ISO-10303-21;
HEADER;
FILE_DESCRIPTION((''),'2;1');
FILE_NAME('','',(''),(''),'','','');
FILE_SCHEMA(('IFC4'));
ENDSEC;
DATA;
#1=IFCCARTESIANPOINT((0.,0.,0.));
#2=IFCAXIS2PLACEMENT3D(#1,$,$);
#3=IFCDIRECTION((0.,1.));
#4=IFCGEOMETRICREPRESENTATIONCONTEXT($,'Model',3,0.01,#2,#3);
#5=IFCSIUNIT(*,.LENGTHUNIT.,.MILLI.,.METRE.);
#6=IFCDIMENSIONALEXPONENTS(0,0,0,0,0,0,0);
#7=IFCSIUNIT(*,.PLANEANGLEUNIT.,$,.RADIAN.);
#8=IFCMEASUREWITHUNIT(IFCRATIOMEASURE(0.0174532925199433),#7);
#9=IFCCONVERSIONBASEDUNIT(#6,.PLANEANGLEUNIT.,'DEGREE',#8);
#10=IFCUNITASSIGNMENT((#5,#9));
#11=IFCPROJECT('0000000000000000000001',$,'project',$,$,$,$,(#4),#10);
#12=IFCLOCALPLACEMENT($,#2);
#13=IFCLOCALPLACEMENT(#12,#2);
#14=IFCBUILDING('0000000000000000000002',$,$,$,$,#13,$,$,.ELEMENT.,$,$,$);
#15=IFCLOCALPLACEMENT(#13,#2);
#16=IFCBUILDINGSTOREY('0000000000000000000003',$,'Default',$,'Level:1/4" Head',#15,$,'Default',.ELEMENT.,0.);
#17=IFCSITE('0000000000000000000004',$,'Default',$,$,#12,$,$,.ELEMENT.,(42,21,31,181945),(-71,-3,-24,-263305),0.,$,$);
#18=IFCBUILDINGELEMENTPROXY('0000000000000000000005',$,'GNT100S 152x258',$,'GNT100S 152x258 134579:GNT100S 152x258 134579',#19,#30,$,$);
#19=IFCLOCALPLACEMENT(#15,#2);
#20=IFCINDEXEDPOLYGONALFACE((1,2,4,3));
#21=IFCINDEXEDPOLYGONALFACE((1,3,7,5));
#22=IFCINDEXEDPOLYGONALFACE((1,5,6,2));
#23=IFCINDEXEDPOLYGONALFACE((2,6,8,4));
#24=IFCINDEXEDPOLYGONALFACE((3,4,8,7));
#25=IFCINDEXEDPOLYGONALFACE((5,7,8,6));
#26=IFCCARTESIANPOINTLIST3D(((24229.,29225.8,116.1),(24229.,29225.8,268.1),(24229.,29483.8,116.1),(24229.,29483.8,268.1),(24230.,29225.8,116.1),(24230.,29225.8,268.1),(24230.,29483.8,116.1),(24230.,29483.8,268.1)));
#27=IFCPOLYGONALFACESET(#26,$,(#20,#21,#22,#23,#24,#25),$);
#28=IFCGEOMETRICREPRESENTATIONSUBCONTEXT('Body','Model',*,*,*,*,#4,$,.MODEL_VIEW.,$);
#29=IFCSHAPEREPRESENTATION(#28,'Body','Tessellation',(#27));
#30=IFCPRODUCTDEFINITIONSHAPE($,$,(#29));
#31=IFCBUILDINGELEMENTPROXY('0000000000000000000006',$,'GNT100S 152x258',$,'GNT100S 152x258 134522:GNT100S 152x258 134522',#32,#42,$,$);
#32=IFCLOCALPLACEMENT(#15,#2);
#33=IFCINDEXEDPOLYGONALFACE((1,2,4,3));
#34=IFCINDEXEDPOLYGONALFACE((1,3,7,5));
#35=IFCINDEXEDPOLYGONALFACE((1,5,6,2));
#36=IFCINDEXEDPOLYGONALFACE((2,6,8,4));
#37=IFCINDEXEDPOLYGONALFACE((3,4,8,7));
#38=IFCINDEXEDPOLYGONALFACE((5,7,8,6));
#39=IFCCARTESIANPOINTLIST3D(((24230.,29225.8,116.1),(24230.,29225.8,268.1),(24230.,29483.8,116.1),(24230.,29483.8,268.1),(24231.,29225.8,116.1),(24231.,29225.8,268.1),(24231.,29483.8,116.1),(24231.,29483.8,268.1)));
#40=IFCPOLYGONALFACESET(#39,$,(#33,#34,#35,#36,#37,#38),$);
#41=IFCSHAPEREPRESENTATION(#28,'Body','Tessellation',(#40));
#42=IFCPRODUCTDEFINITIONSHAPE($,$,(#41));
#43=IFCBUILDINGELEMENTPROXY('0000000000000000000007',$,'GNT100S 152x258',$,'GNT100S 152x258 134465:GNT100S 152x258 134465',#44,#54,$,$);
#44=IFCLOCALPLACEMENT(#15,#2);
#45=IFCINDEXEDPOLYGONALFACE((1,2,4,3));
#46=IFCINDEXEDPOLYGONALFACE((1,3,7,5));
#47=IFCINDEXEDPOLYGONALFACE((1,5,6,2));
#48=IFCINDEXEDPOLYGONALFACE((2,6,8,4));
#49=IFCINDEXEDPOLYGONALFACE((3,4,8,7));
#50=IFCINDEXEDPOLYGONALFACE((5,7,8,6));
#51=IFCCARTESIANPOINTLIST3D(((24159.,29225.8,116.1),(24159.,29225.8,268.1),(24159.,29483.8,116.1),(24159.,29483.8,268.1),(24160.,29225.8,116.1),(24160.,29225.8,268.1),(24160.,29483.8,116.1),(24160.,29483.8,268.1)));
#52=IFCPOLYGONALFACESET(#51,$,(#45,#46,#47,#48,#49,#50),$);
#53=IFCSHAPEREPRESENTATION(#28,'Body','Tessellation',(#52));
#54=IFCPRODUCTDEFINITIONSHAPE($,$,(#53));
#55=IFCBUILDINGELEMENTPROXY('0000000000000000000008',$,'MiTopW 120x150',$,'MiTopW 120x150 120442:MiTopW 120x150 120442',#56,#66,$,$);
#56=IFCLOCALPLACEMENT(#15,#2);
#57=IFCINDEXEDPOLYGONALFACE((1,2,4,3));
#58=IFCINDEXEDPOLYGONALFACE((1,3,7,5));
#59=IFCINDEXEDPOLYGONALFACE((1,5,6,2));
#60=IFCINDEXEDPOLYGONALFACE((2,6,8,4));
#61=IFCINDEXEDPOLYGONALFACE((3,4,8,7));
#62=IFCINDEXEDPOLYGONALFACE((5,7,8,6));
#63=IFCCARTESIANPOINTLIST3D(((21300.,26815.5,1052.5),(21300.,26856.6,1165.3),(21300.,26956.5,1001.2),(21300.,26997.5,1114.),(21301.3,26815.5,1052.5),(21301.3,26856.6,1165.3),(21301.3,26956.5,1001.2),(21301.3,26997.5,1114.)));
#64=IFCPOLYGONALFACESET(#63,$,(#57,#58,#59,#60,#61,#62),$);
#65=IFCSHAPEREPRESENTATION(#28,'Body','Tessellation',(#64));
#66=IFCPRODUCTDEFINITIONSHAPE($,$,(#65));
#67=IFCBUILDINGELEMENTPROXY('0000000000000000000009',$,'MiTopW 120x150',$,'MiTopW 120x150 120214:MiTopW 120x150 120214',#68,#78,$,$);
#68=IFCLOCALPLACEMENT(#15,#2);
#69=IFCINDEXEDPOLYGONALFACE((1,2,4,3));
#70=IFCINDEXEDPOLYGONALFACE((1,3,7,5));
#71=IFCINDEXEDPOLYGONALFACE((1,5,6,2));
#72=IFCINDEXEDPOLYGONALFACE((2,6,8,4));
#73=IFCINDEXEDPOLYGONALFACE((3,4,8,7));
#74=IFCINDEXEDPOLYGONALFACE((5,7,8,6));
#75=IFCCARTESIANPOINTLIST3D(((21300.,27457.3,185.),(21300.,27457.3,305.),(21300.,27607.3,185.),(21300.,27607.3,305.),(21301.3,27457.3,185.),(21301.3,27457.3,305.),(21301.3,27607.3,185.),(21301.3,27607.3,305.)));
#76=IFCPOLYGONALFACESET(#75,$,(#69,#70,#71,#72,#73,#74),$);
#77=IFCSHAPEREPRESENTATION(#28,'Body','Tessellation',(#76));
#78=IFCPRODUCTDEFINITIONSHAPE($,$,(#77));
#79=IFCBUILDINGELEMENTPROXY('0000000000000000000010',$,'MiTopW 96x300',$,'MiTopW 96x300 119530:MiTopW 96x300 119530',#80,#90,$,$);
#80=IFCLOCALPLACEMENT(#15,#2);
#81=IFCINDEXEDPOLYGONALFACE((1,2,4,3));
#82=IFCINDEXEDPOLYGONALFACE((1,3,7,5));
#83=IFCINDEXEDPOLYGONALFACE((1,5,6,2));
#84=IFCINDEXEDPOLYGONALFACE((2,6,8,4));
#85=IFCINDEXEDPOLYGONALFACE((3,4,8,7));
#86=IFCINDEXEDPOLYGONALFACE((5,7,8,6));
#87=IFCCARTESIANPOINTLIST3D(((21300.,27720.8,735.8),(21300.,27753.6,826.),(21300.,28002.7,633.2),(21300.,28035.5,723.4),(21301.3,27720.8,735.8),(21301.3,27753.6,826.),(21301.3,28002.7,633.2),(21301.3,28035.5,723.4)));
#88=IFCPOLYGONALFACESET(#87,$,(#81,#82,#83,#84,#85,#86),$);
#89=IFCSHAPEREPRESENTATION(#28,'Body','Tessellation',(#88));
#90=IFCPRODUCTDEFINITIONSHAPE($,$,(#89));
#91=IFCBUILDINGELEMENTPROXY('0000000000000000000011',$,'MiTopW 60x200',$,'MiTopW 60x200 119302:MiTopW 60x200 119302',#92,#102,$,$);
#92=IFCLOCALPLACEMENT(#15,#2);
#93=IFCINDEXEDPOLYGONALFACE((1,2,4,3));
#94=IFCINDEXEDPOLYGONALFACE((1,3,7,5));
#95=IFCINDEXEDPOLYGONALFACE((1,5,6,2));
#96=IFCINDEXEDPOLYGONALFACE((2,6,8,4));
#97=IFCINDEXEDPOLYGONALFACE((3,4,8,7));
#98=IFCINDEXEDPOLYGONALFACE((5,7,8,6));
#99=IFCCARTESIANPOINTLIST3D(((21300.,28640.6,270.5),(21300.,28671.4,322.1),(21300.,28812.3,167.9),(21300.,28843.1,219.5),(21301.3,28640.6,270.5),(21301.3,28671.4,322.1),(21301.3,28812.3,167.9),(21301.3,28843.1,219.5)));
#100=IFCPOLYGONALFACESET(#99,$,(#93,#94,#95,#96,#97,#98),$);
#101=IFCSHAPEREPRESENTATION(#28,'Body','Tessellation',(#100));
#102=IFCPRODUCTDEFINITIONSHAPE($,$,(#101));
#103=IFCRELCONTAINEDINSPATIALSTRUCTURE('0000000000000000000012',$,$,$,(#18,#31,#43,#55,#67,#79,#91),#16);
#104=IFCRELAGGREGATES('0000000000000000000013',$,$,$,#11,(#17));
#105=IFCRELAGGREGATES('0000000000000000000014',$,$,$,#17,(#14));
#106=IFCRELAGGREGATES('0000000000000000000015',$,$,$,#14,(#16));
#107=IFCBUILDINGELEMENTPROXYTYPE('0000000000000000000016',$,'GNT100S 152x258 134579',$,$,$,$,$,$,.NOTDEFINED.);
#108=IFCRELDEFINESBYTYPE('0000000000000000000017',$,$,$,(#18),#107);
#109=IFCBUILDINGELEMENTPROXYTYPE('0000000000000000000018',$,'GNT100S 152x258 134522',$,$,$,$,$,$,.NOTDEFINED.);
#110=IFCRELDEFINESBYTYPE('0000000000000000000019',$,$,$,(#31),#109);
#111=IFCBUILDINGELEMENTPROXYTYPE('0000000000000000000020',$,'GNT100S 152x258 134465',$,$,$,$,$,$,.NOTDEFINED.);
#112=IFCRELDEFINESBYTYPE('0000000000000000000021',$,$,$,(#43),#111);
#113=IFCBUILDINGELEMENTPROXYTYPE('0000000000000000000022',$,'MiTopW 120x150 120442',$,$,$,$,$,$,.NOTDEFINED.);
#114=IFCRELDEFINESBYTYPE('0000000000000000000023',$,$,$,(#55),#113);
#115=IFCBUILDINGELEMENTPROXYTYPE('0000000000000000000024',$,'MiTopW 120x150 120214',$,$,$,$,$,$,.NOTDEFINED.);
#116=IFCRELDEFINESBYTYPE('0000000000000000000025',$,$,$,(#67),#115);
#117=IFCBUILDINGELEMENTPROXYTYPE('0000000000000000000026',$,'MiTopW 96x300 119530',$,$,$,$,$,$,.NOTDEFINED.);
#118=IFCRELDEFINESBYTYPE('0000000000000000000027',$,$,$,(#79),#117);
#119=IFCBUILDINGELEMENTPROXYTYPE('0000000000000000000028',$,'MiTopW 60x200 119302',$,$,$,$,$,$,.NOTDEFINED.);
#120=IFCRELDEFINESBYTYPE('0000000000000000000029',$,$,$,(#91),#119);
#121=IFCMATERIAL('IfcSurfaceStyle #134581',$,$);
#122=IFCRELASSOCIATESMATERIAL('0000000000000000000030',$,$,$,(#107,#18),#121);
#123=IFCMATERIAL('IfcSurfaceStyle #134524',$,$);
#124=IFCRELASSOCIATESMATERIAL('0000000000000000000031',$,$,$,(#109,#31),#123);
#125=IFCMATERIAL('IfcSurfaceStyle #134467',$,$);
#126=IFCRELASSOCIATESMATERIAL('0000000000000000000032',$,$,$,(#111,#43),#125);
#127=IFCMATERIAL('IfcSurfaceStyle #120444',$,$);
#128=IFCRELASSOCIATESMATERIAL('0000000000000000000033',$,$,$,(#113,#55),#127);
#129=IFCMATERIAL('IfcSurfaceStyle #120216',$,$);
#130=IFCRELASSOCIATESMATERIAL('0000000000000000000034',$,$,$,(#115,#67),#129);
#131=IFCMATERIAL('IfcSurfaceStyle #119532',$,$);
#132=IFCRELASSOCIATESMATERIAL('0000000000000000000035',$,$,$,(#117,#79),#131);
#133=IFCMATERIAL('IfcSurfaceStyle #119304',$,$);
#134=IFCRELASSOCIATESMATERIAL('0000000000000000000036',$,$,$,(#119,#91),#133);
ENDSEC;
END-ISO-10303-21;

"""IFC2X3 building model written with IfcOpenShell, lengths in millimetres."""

from ifc_helpers import new_model, entity, si_unit, converted_unit, direction, frame, origin, origin_2d_with_axis, place, context, subcontext, project, spatial, polyline, rectangle, outline, extrude, source, transform, mapped, material, type_object, type_shapes, element, save


model = new_model("IFC2X3")

# Units and contexts
model_context = context("Model", 3, precision=0.01, world=origin(), true_north=direction((0.0, 1.0)))
body_context = subcontext(model_context, "Body", "Model", "MODEL_VIEW")
ifc_project = project(units=[si_unit("LENGTHUNIT", "METRE", prefix="MILLI"), converted_unit("PLANEANGLEUNIT", "DEGREE", entity("IfcRatioMeasure", 0.0174532925199433), si_unit("PLANEANGLEUNIT", "RADIAN"), dimensions=[0, 0, 0, 0, 0, 0, 0])], contexts=[model_context])

# Site, building, storey
site_placement = place(None, origin())
site = spatial("IfcSite", under=ifc_project, at=site_placement, Name="Default", CompositionType="ELEMENT", RefLatitude=(42, 21, 31, 181945), RefLongitude=(-71, -3, -24, -263305), RefElevation=0.0)
building_placement = place(site_placement, origin())
building = spatial("IfcBuilding", under=site, at=building_placement, CompositionType="ELEMENT")
storey_placement = place(building_placement, origin())
storey = spatial("IfcBuildingStorey", under=building, at=storey_placement, Name="Default", ObjectType="Level:1/4\" Head", LongName="Default", CompositionType="ELEMENT", Elevation=0.0)

# Building element proxies
ifc_material_1 = material(Name="IfcSurfaceStyle #134581")
building_element_proxy_type_1 = type_object("IfcBuildingElementProxyType", Name="GNT100S 152x258 134579", PredefinedType="NOTDEFINED", material=ifc_material_1)
shared_shape_1 = source(origin(), body_context, "Body", "SweptSolid", [
    extrude(rectangle(XDim=258.0, YDim=152.0, at=origin_2d_with_axis()), frame((129.0, 76.0, 0.0), z_axis=(0.0, 0.0, 1.0), x_axis=(-1.0, 0.0, 0.0)), (0.0, 0.0, 1.0), 1.0),
])
type_shapes(building_element_proxy_type_1, [shared_shape_1])
proxy_1_placement = place(building_placement, frame((24230.0, 29483.8, 116.1), z_axis=(-1.0, 0.0, 0.0), x_axis=(0.0, -1.0, 0.0)))
element("IfcBuildingElementProxy", 1, at=proxy_1_placement, inside=storey, type_object=building_element_proxy_type_1, material=ifc_material_1, Name="GNT100S 152x258", ObjectType="GNT100S 152x258 134579:GNT100S 152x258 134579", context=body_context, shape_type="MappedRepresentation", body=[
    mapped(shared_shape_1, transform((0.0, 0.0, 0.0), scale=1.0)),
])
ifc_material_2 = material(Name="IfcSurfaceStyle #134524")
building_element_proxy_type_2 = type_object("IfcBuildingElementProxyType", Name="GNT100S 152x258 134522", PredefinedType="NOTDEFINED", material=ifc_material_2)
shared_shape_2 = source(origin(), body_context, "Body", "SweptSolid", [
    extrude(rectangle(XDim=258.0, YDim=152.0, at=origin_2d_with_axis()), frame((129.0, 76.0, 0.0), z_axis=(0.0, 0.0, 1.0), x_axis=(-1.0, 0.0, 0.0)), (0.0, 0.0, 1.0), 1.0),
])
type_shapes(building_element_proxy_type_2, [shared_shape_2])
proxy_2_placement = place(building_placement, frame((24231.0, 29483.8, 116.1), z_axis=(-1.0, 0.0, 0.0), x_axis=(0.0, -1.0, 0.0)))
element("IfcBuildingElementProxy", 2, at=proxy_2_placement, inside=storey, type_object=building_element_proxy_type_2, material=ifc_material_2, Name="GNT100S 152x258", ObjectType="GNT100S 152x258 134522:GNT100S 152x258 134522", context=body_context, shape_type="MappedRepresentation", body=[
    mapped(shared_shape_2, transform((0.0, 0.0, 0.0), scale=1.0)),
])
ifc_material_3 = material(Name="IfcSurfaceStyle #134467")
building_element_proxy_type_3 = type_object("IfcBuildingElementProxyType", Name="GNT100S 152x258 134465", PredefinedType="NOTDEFINED", material=ifc_material_3)
shared_shape_3 = source(origin(), body_context, "Body", "SweptSolid", [
    extrude(rectangle(XDim=258.0, YDim=152.0, at=origin_2d_with_axis()), frame((129.0, 76.0, 0.0), z_axis=(0.0, 0.0, 1.0), x_axis=(-1.0, 0.0, 0.0)), (0.0, 0.0, 1.0), 1.0),
])
type_shapes(building_element_proxy_type_3, [shared_shape_3])
proxy_3_placement = place(building_placement, frame((24160.0, 29483.8, 116.1), z_axis=(-1.0, 0.0, 0.0), x_axis=(0.0, -1.0, 0.0)))
element("IfcBuildingElementProxy", 3, at=proxy_3_placement, inside=storey, type_object=building_element_proxy_type_3, material=ifc_material_3, Name="GNT100S 152x258", ObjectType="GNT100S 152x258 134465:GNT100S 152x258 134465", context=body_context, shape_type="MappedRepresentation", body=[
    mapped(shared_shape_3, transform((0.0, 0.0, 0.0), scale=1.0)),
])
ifc_material_4 = material(Name="IfcSurfaceStyle #120444")
building_element_proxy_type_4 = type_object("IfcBuildingElementProxyType", Name="MiTopW 120x150 120442", PredefinedType="NOTDEFINED", material=ifc_material_4)
shared_shape_4 = source(origin(), body_context, "Body", "SweptSolid", [
    extrude(outline(polyline([(-75.0, -60.0), (75.0, -60.0), (75.0, 60.0), (-75.0, 60.0), (-75.0, -60.0)])), frame((75.0, 60.0, 0.0), z_axis=(0.0, 0.0, 1.0), x_axis=(-1.0, 0.0, 0.0)), (0.0, 0.0, 1.0), 1.3),
])
type_shapes(building_element_proxy_type_4, [shared_shape_4])
proxy_4_placement = place(building_placement, frame((21301.3, 26956.5, 1001.2), z_axis=(-1.0, 0.0, 0.0), x_axis=(0.0, -0.939693, 0.34202)))
element("IfcBuildingElementProxy", 4, at=proxy_4_placement, inside=storey, type_object=building_element_proxy_type_4, material=ifc_material_4, Name="MiTopW 120x150", ObjectType="MiTopW 120x150 120442:MiTopW 120x150 120442", context=body_context, shape_type="MappedRepresentation", body=[
    mapped(shared_shape_4, transform((0.0, 0.0, 0.0), scale=1.0)),
])
ifc_material_5 = material(Name="IfcSurfaceStyle #120216")
building_element_proxy_type_5 = type_object("IfcBuildingElementProxyType", Name="MiTopW 120x150 120214", PredefinedType="NOTDEFINED", material=ifc_material_5)
shared_shape_5 = source(origin(), body_context, "Body", "SweptSolid", [
    extrude(rectangle(XDim=150.0, YDim=120.0, at=origin_2d_with_axis()), frame((75.0, 60.0, 0.0), z_axis=(0.0, 0.0, 1.0), x_axis=(-1.0, 0.0, 0.0)), (0.0, 0.0, 1.0), 1.3),
])
type_shapes(building_element_proxy_type_5, [shared_shape_5])
proxy_5_placement = place(building_placement, frame((21301.3, 27607.3, 185.0), z_axis=(-1.0, 0.0, 0.0), x_axis=(0.0, -1.0, 0.0)))
element("IfcBuildingElementProxy", 5, at=proxy_5_placement, inside=storey, type_object=building_element_proxy_type_5, material=ifc_material_5, Name="MiTopW 120x150", ObjectType="MiTopW 120x150 120214:MiTopW 120x150 120214", context=body_context, shape_type="MappedRepresentation", body=[
    mapped(shared_shape_5, transform((0.0, 0.0, 0.0), scale=1.0)),
])
ifc_material_6 = material(Name="IfcSurfaceStyle #119532")
building_element_proxy_type_6 = type_object("IfcBuildingElementProxyType", Name="MiTopW 96x300 119530", PredefinedType="NOTDEFINED", material=ifc_material_6)
shared_shape_6 = source(origin(), body_context, "Body", "SweptSolid", [
    extrude(outline(polyline([(-150.0, -48.0), (150.0, -48.0), (150.0, 48.0), (-150.0, 48.0), (-150.0, -48.0)])), frame((150.0, 48.0, 0.0), z_axis=(0.0, 0.0, 1.0), x_axis=(-1.0, 0.0, 0.0)), (0.0, 0.0, 1.0), 1.3),
])
type_shapes(building_element_proxy_type_6, [shared_shape_6])
proxy_6_placement = place(building_placement, frame((21301.3, 28002.7, 633.2), z_axis=(-1.0, 0.0, 0.0), x_axis=(0.0, -0.939693, 0.34202)))
element("IfcBuildingElementProxy", 6, at=proxy_6_placement, inside=storey, type_object=building_element_proxy_type_6, material=ifc_material_6, Name="MiTopW 96x300", ObjectType="MiTopW 96x300 119530:MiTopW 96x300 119530", context=body_context, shape_type="MappedRepresentation", body=[
    mapped(shared_shape_6, transform((0.0, 0.0, 0.0), scale=1.0)),
])
ifc_material_7 = material(Name="IfcSurfaceStyle #119304")
building_element_proxy_type_7 = type_object("IfcBuildingElementProxyType", Name="MiTopW 60x200 119302", PredefinedType="NOTDEFINED", material=ifc_material_7)
shared_shape_7 = source(origin(), body_context, "Body", "SweptSolid", [
    extrude(outline(polyline([(-100.0, -30.0), (100.0, -30.0), (100.0, 30.0), (-100.0, 30.0), (-100.0, -30.0)])), frame((100.0, 30.0, 0.0), z_axis=(0.0, 0.0, 1.0), x_axis=(-1.0, 0.0, 0.0)), (0.0, 0.0, 1.0), 1.3),
])
type_shapes(building_element_proxy_type_7, [shared_shape_7])
proxy_7_placement = place(building_placement, frame((21301.3, 28812.3, 167.9), z_axis=(-1.0, 0.0, 0.0), x_axis=(0.0, -0.858392, 0.512994)))
element("IfcBuildingElementProxy", 7, at=proxy_7_placement, inside=storey, type_object=building_element_proxy_type_7, material=ifc_material_7, Name="MiTopW 60x200", ObjectType="MiTopW 60x200 119302:MiTopW 60x200 119302", context=body_context, shape_type="MappedRepresentation", body=[
    mapped(shared_shape_7, transform((0.0, 0.0, 0.0), scale=1.0)),
])

save(model, "model.ifc")
